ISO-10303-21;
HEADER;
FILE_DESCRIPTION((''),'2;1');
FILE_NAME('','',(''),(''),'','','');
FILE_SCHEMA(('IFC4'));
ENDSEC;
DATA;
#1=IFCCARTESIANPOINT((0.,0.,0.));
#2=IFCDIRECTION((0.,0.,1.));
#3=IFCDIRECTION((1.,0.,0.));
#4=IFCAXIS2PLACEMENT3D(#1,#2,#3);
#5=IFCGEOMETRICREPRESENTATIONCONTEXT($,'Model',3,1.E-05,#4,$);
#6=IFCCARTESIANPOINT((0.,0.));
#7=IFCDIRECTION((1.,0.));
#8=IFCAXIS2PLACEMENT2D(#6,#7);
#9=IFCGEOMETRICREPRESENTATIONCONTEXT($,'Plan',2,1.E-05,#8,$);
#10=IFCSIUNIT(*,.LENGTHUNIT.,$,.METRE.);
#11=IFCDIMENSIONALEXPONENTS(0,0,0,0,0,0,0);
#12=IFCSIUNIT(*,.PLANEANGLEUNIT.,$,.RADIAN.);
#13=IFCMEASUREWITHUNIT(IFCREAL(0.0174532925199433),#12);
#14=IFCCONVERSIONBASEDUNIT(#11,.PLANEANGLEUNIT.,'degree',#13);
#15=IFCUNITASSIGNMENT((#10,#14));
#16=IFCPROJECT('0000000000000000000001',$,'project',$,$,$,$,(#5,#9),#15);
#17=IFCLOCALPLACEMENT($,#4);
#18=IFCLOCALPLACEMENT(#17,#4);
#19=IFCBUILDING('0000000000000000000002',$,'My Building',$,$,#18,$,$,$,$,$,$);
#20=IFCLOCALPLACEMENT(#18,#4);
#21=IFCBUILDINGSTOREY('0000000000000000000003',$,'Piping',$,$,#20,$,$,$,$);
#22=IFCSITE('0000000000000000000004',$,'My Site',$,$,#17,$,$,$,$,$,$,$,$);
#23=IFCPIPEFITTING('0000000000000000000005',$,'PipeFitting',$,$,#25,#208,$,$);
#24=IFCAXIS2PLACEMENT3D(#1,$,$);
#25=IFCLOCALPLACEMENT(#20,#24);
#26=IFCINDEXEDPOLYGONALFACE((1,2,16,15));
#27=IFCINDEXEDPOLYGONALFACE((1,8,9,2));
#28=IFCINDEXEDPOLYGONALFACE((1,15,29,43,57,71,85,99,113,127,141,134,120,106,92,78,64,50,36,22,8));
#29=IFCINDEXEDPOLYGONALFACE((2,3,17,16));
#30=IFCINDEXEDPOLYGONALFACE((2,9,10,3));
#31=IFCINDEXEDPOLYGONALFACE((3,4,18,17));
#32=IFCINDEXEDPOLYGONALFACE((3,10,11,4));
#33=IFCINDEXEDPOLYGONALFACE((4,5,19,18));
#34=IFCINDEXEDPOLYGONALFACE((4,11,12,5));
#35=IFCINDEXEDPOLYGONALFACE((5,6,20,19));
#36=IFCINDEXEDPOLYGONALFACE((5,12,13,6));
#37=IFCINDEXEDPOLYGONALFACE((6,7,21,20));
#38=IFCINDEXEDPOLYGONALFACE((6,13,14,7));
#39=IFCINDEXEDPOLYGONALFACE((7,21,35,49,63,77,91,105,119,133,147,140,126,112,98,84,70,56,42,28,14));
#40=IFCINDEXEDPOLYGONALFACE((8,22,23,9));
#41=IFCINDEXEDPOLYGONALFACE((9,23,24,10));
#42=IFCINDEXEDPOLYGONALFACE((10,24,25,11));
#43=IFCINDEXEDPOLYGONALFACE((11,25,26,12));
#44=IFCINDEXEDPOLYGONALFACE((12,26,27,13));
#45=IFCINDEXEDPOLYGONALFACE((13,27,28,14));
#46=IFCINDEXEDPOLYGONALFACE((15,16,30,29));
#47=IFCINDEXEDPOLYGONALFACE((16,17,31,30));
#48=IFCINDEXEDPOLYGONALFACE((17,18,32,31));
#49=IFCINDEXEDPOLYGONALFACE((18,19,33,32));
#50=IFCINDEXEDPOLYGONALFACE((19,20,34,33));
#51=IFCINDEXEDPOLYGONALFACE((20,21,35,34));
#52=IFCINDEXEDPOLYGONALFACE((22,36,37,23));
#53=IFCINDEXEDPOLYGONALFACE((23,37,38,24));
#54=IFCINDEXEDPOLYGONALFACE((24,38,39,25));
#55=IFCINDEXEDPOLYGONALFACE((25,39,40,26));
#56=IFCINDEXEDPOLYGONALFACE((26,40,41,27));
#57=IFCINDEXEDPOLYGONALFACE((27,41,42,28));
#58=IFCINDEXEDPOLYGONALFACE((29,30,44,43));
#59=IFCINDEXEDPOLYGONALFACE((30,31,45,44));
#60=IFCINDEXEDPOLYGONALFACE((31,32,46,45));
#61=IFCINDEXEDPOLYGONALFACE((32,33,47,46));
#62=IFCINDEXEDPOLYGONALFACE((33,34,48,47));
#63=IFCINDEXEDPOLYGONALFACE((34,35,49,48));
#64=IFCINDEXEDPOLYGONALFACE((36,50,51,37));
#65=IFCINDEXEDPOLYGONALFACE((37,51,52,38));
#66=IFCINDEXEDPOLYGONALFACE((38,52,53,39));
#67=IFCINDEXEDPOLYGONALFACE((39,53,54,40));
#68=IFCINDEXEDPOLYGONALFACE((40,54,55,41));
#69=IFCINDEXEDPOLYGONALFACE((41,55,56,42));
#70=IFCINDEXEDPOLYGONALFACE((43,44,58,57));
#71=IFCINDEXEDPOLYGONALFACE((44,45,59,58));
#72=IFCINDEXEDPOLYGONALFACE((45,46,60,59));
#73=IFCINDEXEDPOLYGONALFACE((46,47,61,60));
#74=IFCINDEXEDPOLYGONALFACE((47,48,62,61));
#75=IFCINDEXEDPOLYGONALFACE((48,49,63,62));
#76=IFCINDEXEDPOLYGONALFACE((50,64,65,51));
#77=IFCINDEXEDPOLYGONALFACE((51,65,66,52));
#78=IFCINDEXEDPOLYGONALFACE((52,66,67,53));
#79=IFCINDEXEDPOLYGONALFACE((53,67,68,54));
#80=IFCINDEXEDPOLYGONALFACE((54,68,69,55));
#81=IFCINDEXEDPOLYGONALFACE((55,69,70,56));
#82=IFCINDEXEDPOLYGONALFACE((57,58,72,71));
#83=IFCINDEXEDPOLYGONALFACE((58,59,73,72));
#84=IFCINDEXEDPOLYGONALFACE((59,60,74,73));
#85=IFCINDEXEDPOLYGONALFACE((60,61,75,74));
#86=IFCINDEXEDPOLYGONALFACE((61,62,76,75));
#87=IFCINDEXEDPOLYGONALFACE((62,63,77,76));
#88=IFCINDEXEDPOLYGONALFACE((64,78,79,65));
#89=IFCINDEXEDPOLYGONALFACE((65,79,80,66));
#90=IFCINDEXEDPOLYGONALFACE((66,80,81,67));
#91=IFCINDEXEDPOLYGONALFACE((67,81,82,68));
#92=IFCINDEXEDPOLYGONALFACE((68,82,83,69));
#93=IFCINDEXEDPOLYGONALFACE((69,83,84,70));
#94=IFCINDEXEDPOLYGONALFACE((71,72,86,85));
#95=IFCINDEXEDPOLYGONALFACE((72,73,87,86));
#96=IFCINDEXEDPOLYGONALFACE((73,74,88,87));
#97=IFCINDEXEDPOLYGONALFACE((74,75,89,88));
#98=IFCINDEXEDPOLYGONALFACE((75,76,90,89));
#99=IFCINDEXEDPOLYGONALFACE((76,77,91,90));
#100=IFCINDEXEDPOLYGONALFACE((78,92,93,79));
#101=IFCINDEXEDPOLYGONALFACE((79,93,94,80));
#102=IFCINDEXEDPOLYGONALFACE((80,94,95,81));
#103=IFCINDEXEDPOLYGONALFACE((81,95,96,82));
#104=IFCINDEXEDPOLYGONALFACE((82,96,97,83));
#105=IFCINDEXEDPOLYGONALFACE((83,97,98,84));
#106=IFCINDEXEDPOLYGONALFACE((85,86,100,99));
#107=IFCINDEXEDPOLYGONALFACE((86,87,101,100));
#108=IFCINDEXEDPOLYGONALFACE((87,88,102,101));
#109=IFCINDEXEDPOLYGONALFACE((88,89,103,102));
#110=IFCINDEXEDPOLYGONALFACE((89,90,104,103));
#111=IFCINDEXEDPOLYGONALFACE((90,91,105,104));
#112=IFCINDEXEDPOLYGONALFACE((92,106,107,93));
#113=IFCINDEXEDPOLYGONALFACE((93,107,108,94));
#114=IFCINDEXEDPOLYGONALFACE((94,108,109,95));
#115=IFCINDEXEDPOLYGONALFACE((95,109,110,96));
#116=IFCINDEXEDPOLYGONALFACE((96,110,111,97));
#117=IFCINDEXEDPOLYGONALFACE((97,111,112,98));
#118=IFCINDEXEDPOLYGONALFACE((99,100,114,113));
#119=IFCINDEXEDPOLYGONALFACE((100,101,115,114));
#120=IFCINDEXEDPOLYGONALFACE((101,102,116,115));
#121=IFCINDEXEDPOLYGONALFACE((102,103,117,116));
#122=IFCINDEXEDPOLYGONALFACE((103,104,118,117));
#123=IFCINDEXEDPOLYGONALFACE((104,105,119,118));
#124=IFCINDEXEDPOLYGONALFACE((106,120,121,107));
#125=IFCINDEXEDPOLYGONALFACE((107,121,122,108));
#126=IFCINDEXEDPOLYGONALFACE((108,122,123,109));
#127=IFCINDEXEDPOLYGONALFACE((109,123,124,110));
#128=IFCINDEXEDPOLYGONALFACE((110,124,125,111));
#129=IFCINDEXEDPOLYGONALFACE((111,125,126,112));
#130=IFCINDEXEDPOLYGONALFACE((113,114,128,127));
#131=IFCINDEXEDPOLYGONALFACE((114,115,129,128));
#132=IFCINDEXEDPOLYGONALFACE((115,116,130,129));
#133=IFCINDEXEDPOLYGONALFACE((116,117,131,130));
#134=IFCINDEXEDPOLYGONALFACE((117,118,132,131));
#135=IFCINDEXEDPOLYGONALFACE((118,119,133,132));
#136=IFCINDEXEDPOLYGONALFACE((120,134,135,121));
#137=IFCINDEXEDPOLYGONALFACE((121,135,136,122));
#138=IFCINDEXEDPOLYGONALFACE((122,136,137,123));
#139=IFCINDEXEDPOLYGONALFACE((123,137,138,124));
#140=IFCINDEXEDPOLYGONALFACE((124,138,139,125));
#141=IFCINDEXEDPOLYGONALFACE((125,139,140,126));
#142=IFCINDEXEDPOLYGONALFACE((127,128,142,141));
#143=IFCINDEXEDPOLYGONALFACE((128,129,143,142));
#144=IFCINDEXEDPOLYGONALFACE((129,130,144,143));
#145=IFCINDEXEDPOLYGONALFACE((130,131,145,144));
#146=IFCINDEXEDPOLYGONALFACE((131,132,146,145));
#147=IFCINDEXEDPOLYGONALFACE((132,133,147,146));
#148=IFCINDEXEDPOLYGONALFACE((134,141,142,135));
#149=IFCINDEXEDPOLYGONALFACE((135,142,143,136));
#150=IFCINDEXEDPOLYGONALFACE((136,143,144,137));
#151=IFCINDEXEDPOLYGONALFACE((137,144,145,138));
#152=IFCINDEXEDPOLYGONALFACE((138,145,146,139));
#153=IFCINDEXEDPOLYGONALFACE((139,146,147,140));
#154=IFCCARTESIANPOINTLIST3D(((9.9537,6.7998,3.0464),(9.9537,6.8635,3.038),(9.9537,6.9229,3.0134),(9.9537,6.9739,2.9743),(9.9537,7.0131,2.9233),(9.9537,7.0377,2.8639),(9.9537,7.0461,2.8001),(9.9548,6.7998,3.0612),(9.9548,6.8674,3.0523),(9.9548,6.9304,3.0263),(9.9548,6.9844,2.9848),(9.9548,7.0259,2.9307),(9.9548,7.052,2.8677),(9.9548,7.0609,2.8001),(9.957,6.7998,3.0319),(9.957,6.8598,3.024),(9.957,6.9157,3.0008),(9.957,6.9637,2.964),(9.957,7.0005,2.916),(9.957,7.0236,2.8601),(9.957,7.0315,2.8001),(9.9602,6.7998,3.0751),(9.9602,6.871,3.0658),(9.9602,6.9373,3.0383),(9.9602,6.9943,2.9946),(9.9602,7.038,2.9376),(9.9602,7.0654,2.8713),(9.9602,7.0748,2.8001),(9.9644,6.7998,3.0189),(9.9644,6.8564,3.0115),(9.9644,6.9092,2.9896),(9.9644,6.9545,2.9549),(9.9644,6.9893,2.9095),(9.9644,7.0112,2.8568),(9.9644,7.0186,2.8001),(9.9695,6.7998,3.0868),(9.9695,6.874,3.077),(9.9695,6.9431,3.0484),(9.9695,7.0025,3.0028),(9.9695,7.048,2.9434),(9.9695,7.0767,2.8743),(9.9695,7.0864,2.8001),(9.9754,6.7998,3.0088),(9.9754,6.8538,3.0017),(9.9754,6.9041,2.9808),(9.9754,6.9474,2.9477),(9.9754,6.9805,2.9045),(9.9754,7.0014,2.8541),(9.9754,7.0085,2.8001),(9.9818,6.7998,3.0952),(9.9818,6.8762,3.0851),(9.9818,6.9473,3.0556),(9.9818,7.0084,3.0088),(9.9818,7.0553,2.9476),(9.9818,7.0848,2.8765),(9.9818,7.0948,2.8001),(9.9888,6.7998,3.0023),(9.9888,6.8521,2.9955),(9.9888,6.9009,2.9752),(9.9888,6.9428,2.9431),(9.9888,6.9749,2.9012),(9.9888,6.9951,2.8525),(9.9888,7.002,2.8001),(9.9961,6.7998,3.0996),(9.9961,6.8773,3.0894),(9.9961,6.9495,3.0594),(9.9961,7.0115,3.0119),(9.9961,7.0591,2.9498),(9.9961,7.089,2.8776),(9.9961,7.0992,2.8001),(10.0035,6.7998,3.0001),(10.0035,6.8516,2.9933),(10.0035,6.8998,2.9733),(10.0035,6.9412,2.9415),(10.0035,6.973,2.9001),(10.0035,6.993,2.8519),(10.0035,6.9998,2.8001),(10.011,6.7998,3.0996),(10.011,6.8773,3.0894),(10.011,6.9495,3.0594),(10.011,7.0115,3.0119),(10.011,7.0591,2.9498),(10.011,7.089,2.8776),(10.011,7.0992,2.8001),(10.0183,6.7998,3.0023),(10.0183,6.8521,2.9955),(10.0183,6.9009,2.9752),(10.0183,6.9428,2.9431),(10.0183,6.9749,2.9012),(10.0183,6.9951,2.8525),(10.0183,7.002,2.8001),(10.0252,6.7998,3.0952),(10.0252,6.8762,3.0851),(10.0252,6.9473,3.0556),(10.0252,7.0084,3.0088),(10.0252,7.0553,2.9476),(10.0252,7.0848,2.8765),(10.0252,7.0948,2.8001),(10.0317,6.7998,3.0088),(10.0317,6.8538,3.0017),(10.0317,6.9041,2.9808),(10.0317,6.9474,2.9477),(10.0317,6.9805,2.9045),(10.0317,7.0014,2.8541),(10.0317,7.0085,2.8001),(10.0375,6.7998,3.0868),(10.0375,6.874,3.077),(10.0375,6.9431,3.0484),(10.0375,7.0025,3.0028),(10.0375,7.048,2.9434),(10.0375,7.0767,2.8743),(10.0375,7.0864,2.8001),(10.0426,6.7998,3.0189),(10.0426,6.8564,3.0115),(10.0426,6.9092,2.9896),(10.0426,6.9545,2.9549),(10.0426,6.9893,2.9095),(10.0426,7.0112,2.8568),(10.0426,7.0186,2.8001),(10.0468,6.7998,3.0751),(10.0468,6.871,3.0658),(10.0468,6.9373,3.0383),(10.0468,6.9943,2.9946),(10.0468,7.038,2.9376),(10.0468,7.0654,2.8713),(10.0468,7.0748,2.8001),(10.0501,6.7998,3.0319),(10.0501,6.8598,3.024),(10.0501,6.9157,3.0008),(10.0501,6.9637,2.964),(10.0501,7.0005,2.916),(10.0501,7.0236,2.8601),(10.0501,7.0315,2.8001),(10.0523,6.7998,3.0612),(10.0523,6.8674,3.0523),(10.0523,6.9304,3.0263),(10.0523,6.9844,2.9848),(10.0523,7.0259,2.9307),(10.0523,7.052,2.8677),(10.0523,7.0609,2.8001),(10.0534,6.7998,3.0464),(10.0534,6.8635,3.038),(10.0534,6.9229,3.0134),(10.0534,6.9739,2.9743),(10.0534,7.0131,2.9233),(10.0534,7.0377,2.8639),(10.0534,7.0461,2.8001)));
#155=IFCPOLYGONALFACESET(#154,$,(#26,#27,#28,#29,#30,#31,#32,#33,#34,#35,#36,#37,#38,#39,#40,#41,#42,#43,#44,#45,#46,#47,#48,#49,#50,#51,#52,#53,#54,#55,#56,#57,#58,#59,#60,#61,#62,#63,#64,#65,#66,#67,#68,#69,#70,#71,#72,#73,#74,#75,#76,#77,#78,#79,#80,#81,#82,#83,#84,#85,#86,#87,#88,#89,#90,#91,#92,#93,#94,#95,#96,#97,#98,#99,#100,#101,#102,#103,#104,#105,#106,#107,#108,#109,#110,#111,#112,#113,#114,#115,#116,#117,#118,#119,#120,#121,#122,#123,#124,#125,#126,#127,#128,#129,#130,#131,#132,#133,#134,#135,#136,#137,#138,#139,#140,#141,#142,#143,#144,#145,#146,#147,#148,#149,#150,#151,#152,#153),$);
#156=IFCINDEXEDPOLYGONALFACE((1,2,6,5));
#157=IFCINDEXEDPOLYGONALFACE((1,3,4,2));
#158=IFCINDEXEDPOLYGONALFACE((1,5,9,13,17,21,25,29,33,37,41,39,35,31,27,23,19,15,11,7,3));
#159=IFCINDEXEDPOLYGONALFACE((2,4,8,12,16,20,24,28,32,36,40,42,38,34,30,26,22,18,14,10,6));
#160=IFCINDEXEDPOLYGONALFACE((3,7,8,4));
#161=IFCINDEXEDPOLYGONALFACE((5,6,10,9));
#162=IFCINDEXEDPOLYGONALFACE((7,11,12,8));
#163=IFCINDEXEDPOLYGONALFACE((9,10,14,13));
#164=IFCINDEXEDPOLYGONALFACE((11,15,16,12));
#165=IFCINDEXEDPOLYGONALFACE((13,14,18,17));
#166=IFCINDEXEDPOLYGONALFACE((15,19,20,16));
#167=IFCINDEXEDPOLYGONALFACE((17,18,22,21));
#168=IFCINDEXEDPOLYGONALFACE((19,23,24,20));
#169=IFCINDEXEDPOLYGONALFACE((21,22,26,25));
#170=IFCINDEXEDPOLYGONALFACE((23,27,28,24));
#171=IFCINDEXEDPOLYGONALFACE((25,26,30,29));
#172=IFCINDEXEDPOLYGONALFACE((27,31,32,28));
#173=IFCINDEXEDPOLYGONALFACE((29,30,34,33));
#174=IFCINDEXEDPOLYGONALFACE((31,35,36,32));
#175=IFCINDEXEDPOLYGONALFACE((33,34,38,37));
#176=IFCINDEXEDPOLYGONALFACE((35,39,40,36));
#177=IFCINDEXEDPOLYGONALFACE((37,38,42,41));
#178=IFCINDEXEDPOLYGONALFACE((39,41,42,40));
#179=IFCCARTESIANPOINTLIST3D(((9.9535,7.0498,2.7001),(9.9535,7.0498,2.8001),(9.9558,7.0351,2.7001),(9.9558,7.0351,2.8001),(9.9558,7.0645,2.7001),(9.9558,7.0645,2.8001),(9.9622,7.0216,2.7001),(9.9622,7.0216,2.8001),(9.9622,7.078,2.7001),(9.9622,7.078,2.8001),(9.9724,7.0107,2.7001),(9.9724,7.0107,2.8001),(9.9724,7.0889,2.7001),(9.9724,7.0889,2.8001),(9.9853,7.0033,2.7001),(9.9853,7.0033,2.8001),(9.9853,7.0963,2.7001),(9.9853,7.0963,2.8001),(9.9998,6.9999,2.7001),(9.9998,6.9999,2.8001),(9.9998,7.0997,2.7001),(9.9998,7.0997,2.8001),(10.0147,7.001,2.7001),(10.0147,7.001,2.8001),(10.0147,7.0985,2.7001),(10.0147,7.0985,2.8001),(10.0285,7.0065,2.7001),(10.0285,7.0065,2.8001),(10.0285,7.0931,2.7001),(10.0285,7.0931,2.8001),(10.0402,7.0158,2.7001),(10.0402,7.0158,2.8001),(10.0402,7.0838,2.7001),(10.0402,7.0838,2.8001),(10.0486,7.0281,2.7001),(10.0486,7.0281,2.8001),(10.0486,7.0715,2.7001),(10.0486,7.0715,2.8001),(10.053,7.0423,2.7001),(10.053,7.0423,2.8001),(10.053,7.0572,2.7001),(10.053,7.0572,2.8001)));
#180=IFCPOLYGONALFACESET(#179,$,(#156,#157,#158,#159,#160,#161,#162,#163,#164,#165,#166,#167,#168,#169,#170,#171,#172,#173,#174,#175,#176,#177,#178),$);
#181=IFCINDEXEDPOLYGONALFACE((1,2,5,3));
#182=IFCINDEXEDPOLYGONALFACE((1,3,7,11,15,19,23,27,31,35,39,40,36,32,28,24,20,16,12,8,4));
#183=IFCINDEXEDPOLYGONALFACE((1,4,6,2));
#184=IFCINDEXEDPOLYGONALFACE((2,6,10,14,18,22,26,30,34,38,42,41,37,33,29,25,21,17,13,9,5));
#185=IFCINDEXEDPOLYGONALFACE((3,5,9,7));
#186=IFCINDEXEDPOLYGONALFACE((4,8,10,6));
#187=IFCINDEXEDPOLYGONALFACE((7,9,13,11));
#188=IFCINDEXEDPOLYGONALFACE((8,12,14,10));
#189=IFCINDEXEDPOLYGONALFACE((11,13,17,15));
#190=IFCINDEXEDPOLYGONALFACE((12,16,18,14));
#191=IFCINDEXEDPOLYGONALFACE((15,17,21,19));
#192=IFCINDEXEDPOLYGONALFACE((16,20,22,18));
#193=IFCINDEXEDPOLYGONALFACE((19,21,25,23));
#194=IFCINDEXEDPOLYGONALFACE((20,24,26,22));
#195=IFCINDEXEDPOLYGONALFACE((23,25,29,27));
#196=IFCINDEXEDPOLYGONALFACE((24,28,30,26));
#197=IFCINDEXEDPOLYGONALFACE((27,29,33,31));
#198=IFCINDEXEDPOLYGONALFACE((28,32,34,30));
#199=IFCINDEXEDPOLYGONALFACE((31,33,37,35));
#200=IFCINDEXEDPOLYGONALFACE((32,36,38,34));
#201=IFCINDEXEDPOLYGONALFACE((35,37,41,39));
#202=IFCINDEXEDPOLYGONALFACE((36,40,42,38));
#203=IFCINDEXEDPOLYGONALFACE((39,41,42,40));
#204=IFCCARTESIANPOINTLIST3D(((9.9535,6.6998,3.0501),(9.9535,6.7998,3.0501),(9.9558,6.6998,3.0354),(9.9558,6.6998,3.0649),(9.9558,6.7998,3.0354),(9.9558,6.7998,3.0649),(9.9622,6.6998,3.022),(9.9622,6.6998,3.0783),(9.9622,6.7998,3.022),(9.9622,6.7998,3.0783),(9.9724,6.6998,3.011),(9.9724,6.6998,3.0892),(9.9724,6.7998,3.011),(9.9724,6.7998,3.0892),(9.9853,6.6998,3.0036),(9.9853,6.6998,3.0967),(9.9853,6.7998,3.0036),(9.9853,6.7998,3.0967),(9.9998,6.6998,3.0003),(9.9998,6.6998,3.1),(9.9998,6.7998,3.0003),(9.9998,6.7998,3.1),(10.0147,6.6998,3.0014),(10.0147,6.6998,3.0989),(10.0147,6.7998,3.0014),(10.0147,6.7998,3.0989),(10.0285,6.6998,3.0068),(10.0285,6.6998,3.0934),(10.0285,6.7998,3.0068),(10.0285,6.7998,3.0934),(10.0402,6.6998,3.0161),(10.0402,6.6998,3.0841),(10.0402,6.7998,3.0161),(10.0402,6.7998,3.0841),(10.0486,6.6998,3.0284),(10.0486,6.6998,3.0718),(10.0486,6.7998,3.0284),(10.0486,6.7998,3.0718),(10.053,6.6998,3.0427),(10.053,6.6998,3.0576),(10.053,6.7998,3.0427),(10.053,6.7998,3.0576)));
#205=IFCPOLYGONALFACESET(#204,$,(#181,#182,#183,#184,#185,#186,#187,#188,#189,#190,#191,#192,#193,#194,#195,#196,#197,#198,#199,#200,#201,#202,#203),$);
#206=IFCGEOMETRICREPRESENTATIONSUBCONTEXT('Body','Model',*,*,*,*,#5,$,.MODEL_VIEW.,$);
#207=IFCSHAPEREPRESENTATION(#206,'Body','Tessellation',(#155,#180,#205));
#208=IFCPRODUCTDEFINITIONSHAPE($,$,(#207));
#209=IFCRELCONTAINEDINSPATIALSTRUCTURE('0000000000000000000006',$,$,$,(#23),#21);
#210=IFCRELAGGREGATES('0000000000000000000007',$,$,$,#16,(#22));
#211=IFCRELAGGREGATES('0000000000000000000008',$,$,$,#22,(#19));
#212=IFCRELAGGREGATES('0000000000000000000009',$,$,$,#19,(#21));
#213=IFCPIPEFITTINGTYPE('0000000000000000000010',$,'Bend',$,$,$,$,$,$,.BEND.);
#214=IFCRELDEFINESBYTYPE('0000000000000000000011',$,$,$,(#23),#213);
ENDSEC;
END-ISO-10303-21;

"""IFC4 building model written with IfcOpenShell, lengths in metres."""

from ifc_helpers import new_model, entity, si_unit, converted_unit, frame, origin_with_axes, origin_2d_with_axis, place, context, subcontext, project, spatial, circle, extrude, source, transform, mapped, type_object, type_shapes, element, save


model = new_model("IFC4")

# Units and contexts
model_context = context("Model", 3, precision=1e-05, world=origin_with_axes())
plan_context = context("Plan", 2, precision=1e-05, world=origin_2d_with_axis())
body_context = subcontext(model_context, "Body", "Model", "MODEL_VIEW")
ifc_project = project(units=[si_unit("LENGTHUNIT", "METRE"), converted_unit("PLANEANGLEUNIT", "degree", entity("IfcReal", 0.0174532925199433), si_unit("PLANEANGLEUNIT", "RADIAN"), dimensions=[0, 0, 0, 0, 0, 0, 0])], contexts=[model_context, plan_context])

# Site, building, storey
site_placement = place(None, origin_with_axes())
site = spatial("IfcSite", under=ifc_project, at=site_placement, Name="My Site")
building_placement = place(site_placement, origin_with_axes())
building = spatial("IfcBuilding", under=site, at=building_placement, Name="My Building")
storey_placement = place(building_placement, origin_with_axes())
storey = spatial("IfcBuildingStorey", under=building, at=storey_placement, Name="Piping")

# Pipe fitting
pipe_fitting_type_1 = type_object("IfcPipeFittingType", Name="Bend", PredefinedType="BEND")
shared_shape = source(origin_with_axes(), body_context, "Body", "SolidModel", [
    entity("IfcSweptDiskSolid", entity("IfcIndexedPolyCurve", entity("IfcCartesianPointList3D", [[0.0, 0.0, -0.1], [0.0, -0.0732, -0.2768], [0.0, -0.25, -0.35]]), [entity("IfcArcIndex", [1, 2, 3])]), 0.05),
    extrude(circle(Radius=0.05), origin_with_axes(), (0.0, 0.0, -1.0), 0.1),
    extrude(circle(Radius=0.05), frame((0.0, -0.25, -0.35), z_axis=(0.0, -1.0, 0.0), x_axis=(1.0, 0.0, 0.0)), (0.0, 0.0, 1.0), 0.1),
])
type_shapes(pipe_fitting_type_1, [shared_shape])
for number, where, z_axis, x_axis, name in (
    (1, (10.0035, 7.0498, 2.7001), (0.0, 0.0, -1.0), (-1.0, 0.0, 0.0), "PipeFitting"),
):
    element("IfcPipeFitting", number, at=place(storey_placement, frame(where, z_axis=z_axis, x_axis=x_axis)), inside=storey, type_object=pipe_fitting_type_1, Name=name, context=body_context, shape_type="MappedRepresentation", body=[
        mapped(shared_shape, transform((0.0, 0.0, 0.0), x_axis=(1.0, 0.0, 0.0), y_axis=(0.0, 1.0, 0.0), z_axis=(0.0, 0.0, 1.0), scale=1.0)),
    ])

save(model, "model.ifc")
